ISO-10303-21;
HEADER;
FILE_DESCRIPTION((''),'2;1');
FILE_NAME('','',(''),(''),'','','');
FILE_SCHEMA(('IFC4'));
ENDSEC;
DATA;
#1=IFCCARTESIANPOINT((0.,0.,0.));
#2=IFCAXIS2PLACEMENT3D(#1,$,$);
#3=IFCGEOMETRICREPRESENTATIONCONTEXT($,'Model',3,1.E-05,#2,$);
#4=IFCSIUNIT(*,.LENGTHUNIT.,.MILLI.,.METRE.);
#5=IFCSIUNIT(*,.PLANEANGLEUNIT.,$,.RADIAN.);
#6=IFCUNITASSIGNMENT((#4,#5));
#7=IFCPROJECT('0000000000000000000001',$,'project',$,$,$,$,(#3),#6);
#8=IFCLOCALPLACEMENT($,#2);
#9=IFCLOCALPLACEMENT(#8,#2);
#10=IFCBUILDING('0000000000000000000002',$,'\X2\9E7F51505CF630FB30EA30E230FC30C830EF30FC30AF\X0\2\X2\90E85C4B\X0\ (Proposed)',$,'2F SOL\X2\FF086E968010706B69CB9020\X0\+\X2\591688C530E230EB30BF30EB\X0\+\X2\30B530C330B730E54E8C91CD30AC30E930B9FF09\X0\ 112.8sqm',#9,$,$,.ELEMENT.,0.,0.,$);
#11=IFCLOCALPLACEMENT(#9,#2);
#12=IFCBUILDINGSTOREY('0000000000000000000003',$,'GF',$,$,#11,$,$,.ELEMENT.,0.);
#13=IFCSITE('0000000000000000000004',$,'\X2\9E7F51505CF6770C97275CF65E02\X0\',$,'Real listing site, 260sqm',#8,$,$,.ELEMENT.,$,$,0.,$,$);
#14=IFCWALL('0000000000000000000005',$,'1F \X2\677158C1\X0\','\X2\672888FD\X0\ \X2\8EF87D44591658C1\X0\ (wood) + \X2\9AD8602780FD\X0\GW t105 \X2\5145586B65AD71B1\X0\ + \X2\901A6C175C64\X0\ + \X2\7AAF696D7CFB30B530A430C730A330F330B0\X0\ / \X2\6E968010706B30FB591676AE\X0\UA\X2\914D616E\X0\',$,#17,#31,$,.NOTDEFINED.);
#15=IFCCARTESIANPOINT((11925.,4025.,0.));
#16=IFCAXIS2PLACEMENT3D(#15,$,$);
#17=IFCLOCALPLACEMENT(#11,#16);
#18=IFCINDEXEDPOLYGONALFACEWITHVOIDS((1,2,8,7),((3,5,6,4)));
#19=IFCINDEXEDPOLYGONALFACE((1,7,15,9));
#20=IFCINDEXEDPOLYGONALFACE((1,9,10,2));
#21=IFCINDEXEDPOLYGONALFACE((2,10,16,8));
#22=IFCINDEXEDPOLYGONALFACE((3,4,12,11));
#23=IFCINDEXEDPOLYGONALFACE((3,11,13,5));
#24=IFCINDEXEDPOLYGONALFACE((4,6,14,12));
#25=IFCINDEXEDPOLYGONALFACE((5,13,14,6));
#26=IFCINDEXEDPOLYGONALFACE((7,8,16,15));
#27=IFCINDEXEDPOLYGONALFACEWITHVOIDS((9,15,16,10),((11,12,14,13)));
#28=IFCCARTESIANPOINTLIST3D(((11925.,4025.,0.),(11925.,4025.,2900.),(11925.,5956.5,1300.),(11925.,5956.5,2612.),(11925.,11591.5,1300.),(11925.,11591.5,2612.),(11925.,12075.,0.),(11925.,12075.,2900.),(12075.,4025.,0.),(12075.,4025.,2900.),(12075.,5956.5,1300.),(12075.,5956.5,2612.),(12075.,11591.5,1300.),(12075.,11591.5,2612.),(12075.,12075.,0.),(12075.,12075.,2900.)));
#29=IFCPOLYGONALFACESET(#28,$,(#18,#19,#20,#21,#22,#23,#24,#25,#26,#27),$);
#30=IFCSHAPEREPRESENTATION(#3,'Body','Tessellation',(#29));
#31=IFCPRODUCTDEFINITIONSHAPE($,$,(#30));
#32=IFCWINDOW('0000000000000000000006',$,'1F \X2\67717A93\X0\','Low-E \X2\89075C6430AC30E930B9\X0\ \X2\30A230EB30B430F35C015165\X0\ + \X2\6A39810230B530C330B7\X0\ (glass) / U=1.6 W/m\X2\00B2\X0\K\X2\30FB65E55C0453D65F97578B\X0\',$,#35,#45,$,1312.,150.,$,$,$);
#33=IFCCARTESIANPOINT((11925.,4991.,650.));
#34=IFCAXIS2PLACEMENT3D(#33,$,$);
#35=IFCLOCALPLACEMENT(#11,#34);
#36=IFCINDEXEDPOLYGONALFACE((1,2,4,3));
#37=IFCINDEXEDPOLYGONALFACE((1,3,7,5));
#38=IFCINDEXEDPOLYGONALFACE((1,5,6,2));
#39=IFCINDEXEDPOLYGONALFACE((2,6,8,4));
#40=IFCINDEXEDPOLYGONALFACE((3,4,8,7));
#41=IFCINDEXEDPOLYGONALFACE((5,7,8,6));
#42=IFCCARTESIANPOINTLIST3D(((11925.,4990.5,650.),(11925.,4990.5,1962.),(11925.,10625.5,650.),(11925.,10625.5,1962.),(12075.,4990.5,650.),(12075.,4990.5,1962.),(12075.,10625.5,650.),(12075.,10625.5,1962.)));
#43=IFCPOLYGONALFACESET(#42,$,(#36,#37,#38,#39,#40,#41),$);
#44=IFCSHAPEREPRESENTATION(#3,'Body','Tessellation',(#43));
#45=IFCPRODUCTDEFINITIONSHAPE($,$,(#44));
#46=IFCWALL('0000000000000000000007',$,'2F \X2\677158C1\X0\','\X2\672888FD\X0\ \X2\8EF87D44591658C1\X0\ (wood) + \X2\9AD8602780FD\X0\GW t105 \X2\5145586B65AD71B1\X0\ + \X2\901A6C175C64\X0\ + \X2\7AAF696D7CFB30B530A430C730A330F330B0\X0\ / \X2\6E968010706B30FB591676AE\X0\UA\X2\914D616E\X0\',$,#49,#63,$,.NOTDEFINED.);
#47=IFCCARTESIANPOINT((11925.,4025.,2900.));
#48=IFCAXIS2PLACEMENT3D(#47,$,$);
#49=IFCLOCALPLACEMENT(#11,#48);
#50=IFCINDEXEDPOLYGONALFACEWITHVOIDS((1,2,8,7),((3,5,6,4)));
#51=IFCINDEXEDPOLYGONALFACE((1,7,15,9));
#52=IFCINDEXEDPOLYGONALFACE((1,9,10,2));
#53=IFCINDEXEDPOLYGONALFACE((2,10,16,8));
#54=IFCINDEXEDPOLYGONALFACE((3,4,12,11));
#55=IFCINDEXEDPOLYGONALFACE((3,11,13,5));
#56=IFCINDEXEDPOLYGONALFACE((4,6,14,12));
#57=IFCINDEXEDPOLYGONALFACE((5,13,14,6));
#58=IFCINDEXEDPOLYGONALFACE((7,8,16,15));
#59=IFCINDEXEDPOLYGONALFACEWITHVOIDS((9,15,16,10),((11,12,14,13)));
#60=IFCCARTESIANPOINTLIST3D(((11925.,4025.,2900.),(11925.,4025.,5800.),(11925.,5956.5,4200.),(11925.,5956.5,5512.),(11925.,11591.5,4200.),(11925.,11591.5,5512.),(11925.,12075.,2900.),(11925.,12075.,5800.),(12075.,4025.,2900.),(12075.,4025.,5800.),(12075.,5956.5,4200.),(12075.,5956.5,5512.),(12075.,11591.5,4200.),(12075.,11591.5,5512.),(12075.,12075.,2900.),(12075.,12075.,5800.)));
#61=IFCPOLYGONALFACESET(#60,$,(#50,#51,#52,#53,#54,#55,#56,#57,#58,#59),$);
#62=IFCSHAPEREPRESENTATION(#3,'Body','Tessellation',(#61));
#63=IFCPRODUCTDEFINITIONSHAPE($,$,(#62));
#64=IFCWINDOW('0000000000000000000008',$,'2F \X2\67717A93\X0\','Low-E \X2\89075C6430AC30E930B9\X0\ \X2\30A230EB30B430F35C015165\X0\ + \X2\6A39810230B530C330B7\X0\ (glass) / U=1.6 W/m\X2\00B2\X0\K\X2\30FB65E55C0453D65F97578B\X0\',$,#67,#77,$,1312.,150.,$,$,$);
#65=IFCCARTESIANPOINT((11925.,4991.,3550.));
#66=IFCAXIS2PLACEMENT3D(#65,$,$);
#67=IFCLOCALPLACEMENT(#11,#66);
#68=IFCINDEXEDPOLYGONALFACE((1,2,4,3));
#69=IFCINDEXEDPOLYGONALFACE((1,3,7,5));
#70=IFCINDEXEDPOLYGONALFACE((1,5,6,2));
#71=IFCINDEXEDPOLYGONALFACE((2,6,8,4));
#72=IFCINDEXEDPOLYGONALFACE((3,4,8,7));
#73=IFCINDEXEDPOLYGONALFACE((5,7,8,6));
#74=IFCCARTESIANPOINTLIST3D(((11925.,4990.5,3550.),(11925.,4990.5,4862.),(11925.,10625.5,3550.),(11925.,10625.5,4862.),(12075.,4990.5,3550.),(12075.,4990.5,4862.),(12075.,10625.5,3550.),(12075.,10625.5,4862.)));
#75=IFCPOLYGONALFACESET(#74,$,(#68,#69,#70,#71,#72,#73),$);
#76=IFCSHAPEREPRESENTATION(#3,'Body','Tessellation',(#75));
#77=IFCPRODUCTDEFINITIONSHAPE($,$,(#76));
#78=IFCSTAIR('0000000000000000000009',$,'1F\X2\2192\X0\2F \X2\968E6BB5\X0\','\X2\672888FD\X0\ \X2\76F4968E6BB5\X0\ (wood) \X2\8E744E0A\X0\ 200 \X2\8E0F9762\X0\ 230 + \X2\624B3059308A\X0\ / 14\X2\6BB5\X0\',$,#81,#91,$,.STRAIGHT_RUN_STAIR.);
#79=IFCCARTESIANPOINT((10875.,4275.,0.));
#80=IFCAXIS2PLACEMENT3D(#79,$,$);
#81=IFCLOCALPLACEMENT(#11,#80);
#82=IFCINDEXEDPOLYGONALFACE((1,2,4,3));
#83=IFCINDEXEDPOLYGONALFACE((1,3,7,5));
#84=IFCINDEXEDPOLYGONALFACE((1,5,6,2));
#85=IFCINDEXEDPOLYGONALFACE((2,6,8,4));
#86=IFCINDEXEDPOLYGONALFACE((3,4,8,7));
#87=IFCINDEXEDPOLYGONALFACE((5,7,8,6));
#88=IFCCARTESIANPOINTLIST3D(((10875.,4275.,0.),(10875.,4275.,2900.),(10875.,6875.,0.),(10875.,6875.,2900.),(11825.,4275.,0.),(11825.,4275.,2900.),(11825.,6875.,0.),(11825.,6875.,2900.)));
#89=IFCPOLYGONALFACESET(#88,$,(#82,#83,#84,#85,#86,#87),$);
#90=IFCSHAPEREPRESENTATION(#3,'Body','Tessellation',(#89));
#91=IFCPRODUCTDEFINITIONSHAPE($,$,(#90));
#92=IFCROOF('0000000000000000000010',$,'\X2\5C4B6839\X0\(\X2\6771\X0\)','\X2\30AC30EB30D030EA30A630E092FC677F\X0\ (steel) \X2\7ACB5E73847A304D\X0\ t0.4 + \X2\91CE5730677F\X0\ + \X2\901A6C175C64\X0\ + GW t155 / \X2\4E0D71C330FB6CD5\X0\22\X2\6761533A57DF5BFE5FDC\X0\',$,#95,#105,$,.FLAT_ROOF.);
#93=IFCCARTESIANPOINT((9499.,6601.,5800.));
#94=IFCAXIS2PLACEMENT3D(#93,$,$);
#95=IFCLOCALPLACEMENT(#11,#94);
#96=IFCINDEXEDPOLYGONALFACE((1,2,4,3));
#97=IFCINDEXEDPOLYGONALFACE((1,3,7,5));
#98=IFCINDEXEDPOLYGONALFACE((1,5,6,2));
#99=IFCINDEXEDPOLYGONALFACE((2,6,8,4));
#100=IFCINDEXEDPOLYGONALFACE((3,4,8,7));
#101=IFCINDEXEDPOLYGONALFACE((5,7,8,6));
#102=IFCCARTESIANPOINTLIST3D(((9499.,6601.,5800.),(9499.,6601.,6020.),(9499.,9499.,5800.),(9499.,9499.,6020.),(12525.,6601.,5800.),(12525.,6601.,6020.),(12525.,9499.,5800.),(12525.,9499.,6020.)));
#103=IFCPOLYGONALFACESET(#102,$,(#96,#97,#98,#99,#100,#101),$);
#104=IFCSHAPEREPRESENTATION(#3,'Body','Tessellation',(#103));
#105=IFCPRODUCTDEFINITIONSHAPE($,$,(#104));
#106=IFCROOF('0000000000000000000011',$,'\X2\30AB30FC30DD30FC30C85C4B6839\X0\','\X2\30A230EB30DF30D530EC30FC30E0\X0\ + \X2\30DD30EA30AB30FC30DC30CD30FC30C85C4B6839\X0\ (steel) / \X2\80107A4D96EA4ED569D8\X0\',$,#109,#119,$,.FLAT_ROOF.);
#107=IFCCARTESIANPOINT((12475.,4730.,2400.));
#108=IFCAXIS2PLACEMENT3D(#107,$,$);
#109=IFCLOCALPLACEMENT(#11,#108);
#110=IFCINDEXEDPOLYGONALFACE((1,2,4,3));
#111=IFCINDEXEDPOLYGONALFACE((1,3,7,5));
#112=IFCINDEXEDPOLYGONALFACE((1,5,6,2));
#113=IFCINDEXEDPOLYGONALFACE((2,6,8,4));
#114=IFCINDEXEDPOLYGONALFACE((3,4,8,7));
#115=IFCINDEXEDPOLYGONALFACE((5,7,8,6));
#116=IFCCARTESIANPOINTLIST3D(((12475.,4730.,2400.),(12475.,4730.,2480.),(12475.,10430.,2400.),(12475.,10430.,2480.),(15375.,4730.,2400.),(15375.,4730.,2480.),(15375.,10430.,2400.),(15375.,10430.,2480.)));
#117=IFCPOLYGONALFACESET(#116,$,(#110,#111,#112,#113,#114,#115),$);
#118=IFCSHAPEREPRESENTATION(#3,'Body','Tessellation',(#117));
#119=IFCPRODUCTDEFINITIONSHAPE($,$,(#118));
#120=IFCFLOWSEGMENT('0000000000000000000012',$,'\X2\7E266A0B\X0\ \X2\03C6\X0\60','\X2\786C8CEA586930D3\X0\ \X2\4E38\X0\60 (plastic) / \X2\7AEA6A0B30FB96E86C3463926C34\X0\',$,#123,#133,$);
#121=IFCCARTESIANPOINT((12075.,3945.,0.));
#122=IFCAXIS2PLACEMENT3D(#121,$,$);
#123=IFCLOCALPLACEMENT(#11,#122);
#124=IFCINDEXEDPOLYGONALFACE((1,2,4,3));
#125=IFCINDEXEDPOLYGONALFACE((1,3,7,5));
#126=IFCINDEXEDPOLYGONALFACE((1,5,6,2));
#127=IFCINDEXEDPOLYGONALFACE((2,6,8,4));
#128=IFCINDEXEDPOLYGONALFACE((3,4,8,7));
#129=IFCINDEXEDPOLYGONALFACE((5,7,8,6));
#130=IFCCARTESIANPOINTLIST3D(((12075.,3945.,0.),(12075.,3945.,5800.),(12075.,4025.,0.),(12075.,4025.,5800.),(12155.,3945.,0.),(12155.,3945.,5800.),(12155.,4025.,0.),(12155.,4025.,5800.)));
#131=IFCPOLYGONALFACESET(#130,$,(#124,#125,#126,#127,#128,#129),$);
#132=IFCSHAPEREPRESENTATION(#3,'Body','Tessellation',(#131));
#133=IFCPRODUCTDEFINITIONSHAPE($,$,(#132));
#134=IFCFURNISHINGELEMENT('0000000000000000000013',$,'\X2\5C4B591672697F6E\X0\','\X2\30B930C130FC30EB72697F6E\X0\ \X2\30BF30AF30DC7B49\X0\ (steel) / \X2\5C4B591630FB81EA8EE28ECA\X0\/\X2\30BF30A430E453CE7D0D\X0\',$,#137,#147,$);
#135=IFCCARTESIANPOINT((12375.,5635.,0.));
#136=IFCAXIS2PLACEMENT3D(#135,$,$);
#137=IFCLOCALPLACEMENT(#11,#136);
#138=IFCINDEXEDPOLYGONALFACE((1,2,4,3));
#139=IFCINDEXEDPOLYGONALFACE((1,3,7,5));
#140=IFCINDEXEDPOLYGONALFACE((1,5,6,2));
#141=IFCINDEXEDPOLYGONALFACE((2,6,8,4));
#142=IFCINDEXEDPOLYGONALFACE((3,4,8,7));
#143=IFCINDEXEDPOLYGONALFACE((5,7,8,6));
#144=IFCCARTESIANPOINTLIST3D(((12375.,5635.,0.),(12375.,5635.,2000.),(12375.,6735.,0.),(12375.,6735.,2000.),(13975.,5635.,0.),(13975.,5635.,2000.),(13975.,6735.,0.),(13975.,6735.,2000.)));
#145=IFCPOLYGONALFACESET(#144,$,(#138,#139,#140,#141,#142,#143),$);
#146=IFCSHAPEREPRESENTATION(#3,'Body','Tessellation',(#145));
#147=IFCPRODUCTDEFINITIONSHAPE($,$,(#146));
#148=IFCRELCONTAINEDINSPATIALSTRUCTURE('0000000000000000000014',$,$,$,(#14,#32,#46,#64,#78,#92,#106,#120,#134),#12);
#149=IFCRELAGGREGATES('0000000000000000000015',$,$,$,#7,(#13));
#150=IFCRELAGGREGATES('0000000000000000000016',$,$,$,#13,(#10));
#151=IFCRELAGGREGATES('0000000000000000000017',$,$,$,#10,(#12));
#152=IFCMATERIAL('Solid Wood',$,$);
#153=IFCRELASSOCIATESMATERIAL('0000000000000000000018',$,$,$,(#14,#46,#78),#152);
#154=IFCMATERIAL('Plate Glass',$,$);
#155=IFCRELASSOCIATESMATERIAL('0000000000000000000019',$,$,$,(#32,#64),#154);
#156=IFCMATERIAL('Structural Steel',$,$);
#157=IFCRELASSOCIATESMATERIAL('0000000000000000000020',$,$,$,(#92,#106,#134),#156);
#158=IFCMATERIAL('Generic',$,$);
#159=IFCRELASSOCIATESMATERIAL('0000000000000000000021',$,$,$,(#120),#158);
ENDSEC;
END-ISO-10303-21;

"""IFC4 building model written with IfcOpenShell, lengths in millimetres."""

from ifc_helpers import new_model, si_unit, frame, frame_2d, origin, place, context, project, spatial, rectangle, extrude, material, element, fill, save


model = new_model("IFC4")

# Units and contexts
model_context = context("Model", 3, precision=1e-05, world=origin())
ifc_project = project(units=[si_unit("LENGTHUNIT", "METRE", prefix="MILLI"), si_unit("PLANEANGLEUNIT", "RADIAN")], contexts=[model_context])

# Site, building, storey
site_placement = place(None, origin())
site = spatial("IfcSite", under=ifc_project, at=site_placement, Name="鹿児島県霧島市", ObjectType="Real listing site, 260sqm", CompositionType="ELEMENT", RefElevation=0.0)
building_placement = place(site_placement, origin())
building = spatial("IfcBuilding", under=site, at=building_placement, Name="鹿児島・リモートワーク2部屋 (Proposed)", ObjectType="2F SOL（準耐火構造+外装モルタル+サッシュ二重ガラス） 112.8sqm", CompositionType="ELEMENT", ElevationOfRefHeight=0.0, ElevationOfTerrain=0.0)
storey_placement = place(building_placement, origin())
storey = spatial("IfcBuildingStorey", under=building, at=storey_placement, Name="GF", CompositionType="ELEMENT", Elevation=0.0)

# Shared definitions
ifc_material_1 = material(Name="Solid Wood")
ifc_material_2 = material(Name="Structural Steel")

# Walls, openings, windows
wall_1_placement = place(storey_placement, frame((11925.0, 4025.0, 0.0)))
wall_1 = element("IfcWall", 1, at=wall_1_placement, inside=storey, material=ifc_material_1, Name="1F 東壁", Description="木製 軸組外壁 (wood) + 高性能GW t105 充填断熱 + 通気層 + 窯業系サイディング / 準耐火・外皮UA配慮", PredefinedType="NOTDEFINED", context=model_context, shape_type="SweptSolid", body=[
    extrude(rectangle(XDim=150.0, YDim=8050.0, at=frame_2d((75.0, 4025.0))), frame((11925.0, 4025.0, 0.0)), (0.0, 0.0, 1.0), 2900.0),
])
opening_1_placement = place(storey_placement, frame((11925.0, 4991.0, 650.0)))
opening_1 = element("IfcOpeningElement", 2, at=opening_1_placement, cuts=wall_1, PredefinedType="NOTDEFINED", context=model_context, shape_type="SweptSolid", body=[
    extrude(rectangle(XDim=150.0, YDim=5635.0, at=frame_2d((75.0, 2817.0))), frame((11925.0, 4991.0, 650.0)), (0.0, 0.0, 1.0), 1312.0),
])
ifc_material_3 = material(Name="Plate Glass")
window_1_placement = place(storey_placement, frame((11925.0, 4991.0, 650.0)))
window_1 = element("IfcWindow", 3, at=window_1_placement, inside=storey, material=ifc_material_3, Name="1F 東窓", Description="Low-E 複層ガラス アルゴン封入 + 樹脂サッシ (glass) / U=1.6 W/m²K・日射取得型", OverallHeight=1312.0, OverallWidth=150.0, context=model_context, shape_type="SweptSolid", body=[
    extrude(rectangle(XDim=150.0, YDim=5635.0, at=frame_2d((75.0, 2817.0))), frame((11925.0, 4991.0, 650.0)), (0.0, 0.0, 1.0), 1312.0),
])
fill(opening_1, window_1)
wall_2_placement = place(storey_placement, frame((11925.0, 4025.0, 2900.0)))
wall_2 = element("IfcWall", 4, at=wall_2_placement, inside=storey, material=ifc_material_1, Name="2F 東壁", Description="木製 軸組外壁 (wood) + 高性能GW t105 充填断熱 + 通気層 + 窯業系サイディング / 準耐火・外皮UA配慮", PredefinedType="NOTDEFINED", context=model_context, shape_type="SweptSolid", body=[
    extrude(rectangle(XDim=150.0, YDim=8050.0, at=frame_2d((75.0, 4025.0))), frame((11925.0, 4025.0, 2900.0)), (0.0, 0.0, 1.0), 2900.0),
])
opening_2_placement = place(storey_placement, frame((11925.0, 4991.0, 3550.0)))
opening_2 = element("IfcOpeningElement", 5, at=opening_2_placement, cuts=wall_2, PredefinedType="NOTDEFINED", context=model_context, shape_type="SweptSolid", body=[
    extrude(rectangle(XDim=150.0, YDim=5635.0, at=frame_2d((75.0, 2817.0))), frame((11925.0, 4991.0, 3550.0)), (0.0, 0.0, 1.0), 1312.0),
])
window_2_placement = place(storey_placement, frame((11925.0, 4991.0, 3550.0)))
window_2 = element("IfcWindow", 6, at=window_2_placement, inside=storey, material=ifc_material_3, Name="2F 東窓", Description="Low-E 複層ガラス アルゴン封入 + 樹脂サッシ (glass) / U=1.6 W/m²K・日射取得型", OverallHeight=1312.0, OverallWidth=150.0, context=model_context, shape_type="SweptSolid", body=[
    extrude(rectangle(XDim=150.0, YDim=5635.0, at=frame_2d((75.0, 2817.0))), frame((11925.0, 4991.0, 3550.0)), (0.0, 0.0, 1.0), 1312.0),
])
fill(opening_2, window_2)

# Stair
stair_placement = place(storey_placement, frame((10875.0, 4275.0, 0.0)))
element("IfcStair", 7, at=stair_placement, inside=storey, material=ifc_material_1, Name="1F→2F 階段", Description="木製 直階段 (wood) 蹴上 200 踏面 230 + 手すり / 14段", PredefinedType="STRAIGHT_RUN_STAIR", context=model_context, shape_type="SweptSolid", body=[
    extrude(rectangle(XDim=950.0, YDim=2600.0, at=frame_2d((475.0, 1300.0))), frame((10875.0, 4275.0, 0.0)), (0.0, 0.0, 1.0), 2900.0),
])

# Roofs
for number, where, name in (
    (8, (9499.0, 6601.0, 5800.0), "屋根(東)"),
):
    element("IfcRoof", number, at=place(storey_placement, frame(where)), inside=storey, material=ifc_material_2, Name=name, Description="ガルバリウム鋼板 (steel) 立平葺き t0.4 + 野地板 + 通気層 + GW t155 / 不燃・法22条区域対応", PredefinedType="FLAT_ROOF", context=model_context, shape_type="SweptSolid", body=[
        extrude(rectangle(XDim=3026.0, YDim=2898.0, at=frame_2d((1513.0, 1449.0))), frame((9499.0, 6601.0, 5800.0)), (0.0, 0.0, 1.0), 220.0),
    ])
roof_placement = place(storey_placement, frame((12475.0, 4730.0, 2400.0)))
element("IfcRoof", 9, at=roof_placement, inside=storey, material=ifc_material_2, Name="カーポート屋根", Description="アルミフレーム + ポリカーボネート屋根 (steel) / 耐積雪仕様", PredefinedType="FLAT_ROOF", context=model_context, shape_type="SweptSolid", body=[
    extrude(rectangle(XDim=2900.0, YDim=5700.0, at=frame_2d((1450.0, 2850.0))), frame((12475.0, 4730.0, 2400.0)), (0.0, 0.0, 1.0), 80.0),
])

# Flow segment
ifc_material_4 = material(Name="Generic")
flow_segment_placement = place(storey_placement, frame((12075.0, 3945.0, 0.0)))
element("IfcFlowSegment", 10, at=flow_segment_placement, inside=storey, material=ifc_material_4, Name="縦樋 φ60", Description="硬質塩ビ 丸60 (plastic) / 竪樋・雨水排水", context=model_context, shape_type="SweptSolid", body=[
    extrude(rectangle(XDim=80.0, YDim=80.0, at=frame_2d((40.0, 40.0))), frame((12075.0, 3945.0, 0.0)), (0.0, 0.0, 1.0), 5800.0),
])

# Furnishing element
furnishing_placement = place(storey_placement, frame((12375.0, 5635.0, 0.0)))
element("IfcFurnishingElement", 11, at=furnishing_placement, inside=storey, material=ifc_material_2, Name="屋外物置", Description="スチール物置 タクボ等 (steel) / 屋外・自転車/タイヤ収納", context=model_context, shape_type="SweptSolid", body=[
    extrude(rectangle(XDim=1600.0, YDim=1100.0, at=frame_2d((800.0, 550.0))), frame((12375.0, 5635.0, 0.0)), (0.0, 0.0, 1.0), 2000.0),
])

save(model, "model.ifc")
